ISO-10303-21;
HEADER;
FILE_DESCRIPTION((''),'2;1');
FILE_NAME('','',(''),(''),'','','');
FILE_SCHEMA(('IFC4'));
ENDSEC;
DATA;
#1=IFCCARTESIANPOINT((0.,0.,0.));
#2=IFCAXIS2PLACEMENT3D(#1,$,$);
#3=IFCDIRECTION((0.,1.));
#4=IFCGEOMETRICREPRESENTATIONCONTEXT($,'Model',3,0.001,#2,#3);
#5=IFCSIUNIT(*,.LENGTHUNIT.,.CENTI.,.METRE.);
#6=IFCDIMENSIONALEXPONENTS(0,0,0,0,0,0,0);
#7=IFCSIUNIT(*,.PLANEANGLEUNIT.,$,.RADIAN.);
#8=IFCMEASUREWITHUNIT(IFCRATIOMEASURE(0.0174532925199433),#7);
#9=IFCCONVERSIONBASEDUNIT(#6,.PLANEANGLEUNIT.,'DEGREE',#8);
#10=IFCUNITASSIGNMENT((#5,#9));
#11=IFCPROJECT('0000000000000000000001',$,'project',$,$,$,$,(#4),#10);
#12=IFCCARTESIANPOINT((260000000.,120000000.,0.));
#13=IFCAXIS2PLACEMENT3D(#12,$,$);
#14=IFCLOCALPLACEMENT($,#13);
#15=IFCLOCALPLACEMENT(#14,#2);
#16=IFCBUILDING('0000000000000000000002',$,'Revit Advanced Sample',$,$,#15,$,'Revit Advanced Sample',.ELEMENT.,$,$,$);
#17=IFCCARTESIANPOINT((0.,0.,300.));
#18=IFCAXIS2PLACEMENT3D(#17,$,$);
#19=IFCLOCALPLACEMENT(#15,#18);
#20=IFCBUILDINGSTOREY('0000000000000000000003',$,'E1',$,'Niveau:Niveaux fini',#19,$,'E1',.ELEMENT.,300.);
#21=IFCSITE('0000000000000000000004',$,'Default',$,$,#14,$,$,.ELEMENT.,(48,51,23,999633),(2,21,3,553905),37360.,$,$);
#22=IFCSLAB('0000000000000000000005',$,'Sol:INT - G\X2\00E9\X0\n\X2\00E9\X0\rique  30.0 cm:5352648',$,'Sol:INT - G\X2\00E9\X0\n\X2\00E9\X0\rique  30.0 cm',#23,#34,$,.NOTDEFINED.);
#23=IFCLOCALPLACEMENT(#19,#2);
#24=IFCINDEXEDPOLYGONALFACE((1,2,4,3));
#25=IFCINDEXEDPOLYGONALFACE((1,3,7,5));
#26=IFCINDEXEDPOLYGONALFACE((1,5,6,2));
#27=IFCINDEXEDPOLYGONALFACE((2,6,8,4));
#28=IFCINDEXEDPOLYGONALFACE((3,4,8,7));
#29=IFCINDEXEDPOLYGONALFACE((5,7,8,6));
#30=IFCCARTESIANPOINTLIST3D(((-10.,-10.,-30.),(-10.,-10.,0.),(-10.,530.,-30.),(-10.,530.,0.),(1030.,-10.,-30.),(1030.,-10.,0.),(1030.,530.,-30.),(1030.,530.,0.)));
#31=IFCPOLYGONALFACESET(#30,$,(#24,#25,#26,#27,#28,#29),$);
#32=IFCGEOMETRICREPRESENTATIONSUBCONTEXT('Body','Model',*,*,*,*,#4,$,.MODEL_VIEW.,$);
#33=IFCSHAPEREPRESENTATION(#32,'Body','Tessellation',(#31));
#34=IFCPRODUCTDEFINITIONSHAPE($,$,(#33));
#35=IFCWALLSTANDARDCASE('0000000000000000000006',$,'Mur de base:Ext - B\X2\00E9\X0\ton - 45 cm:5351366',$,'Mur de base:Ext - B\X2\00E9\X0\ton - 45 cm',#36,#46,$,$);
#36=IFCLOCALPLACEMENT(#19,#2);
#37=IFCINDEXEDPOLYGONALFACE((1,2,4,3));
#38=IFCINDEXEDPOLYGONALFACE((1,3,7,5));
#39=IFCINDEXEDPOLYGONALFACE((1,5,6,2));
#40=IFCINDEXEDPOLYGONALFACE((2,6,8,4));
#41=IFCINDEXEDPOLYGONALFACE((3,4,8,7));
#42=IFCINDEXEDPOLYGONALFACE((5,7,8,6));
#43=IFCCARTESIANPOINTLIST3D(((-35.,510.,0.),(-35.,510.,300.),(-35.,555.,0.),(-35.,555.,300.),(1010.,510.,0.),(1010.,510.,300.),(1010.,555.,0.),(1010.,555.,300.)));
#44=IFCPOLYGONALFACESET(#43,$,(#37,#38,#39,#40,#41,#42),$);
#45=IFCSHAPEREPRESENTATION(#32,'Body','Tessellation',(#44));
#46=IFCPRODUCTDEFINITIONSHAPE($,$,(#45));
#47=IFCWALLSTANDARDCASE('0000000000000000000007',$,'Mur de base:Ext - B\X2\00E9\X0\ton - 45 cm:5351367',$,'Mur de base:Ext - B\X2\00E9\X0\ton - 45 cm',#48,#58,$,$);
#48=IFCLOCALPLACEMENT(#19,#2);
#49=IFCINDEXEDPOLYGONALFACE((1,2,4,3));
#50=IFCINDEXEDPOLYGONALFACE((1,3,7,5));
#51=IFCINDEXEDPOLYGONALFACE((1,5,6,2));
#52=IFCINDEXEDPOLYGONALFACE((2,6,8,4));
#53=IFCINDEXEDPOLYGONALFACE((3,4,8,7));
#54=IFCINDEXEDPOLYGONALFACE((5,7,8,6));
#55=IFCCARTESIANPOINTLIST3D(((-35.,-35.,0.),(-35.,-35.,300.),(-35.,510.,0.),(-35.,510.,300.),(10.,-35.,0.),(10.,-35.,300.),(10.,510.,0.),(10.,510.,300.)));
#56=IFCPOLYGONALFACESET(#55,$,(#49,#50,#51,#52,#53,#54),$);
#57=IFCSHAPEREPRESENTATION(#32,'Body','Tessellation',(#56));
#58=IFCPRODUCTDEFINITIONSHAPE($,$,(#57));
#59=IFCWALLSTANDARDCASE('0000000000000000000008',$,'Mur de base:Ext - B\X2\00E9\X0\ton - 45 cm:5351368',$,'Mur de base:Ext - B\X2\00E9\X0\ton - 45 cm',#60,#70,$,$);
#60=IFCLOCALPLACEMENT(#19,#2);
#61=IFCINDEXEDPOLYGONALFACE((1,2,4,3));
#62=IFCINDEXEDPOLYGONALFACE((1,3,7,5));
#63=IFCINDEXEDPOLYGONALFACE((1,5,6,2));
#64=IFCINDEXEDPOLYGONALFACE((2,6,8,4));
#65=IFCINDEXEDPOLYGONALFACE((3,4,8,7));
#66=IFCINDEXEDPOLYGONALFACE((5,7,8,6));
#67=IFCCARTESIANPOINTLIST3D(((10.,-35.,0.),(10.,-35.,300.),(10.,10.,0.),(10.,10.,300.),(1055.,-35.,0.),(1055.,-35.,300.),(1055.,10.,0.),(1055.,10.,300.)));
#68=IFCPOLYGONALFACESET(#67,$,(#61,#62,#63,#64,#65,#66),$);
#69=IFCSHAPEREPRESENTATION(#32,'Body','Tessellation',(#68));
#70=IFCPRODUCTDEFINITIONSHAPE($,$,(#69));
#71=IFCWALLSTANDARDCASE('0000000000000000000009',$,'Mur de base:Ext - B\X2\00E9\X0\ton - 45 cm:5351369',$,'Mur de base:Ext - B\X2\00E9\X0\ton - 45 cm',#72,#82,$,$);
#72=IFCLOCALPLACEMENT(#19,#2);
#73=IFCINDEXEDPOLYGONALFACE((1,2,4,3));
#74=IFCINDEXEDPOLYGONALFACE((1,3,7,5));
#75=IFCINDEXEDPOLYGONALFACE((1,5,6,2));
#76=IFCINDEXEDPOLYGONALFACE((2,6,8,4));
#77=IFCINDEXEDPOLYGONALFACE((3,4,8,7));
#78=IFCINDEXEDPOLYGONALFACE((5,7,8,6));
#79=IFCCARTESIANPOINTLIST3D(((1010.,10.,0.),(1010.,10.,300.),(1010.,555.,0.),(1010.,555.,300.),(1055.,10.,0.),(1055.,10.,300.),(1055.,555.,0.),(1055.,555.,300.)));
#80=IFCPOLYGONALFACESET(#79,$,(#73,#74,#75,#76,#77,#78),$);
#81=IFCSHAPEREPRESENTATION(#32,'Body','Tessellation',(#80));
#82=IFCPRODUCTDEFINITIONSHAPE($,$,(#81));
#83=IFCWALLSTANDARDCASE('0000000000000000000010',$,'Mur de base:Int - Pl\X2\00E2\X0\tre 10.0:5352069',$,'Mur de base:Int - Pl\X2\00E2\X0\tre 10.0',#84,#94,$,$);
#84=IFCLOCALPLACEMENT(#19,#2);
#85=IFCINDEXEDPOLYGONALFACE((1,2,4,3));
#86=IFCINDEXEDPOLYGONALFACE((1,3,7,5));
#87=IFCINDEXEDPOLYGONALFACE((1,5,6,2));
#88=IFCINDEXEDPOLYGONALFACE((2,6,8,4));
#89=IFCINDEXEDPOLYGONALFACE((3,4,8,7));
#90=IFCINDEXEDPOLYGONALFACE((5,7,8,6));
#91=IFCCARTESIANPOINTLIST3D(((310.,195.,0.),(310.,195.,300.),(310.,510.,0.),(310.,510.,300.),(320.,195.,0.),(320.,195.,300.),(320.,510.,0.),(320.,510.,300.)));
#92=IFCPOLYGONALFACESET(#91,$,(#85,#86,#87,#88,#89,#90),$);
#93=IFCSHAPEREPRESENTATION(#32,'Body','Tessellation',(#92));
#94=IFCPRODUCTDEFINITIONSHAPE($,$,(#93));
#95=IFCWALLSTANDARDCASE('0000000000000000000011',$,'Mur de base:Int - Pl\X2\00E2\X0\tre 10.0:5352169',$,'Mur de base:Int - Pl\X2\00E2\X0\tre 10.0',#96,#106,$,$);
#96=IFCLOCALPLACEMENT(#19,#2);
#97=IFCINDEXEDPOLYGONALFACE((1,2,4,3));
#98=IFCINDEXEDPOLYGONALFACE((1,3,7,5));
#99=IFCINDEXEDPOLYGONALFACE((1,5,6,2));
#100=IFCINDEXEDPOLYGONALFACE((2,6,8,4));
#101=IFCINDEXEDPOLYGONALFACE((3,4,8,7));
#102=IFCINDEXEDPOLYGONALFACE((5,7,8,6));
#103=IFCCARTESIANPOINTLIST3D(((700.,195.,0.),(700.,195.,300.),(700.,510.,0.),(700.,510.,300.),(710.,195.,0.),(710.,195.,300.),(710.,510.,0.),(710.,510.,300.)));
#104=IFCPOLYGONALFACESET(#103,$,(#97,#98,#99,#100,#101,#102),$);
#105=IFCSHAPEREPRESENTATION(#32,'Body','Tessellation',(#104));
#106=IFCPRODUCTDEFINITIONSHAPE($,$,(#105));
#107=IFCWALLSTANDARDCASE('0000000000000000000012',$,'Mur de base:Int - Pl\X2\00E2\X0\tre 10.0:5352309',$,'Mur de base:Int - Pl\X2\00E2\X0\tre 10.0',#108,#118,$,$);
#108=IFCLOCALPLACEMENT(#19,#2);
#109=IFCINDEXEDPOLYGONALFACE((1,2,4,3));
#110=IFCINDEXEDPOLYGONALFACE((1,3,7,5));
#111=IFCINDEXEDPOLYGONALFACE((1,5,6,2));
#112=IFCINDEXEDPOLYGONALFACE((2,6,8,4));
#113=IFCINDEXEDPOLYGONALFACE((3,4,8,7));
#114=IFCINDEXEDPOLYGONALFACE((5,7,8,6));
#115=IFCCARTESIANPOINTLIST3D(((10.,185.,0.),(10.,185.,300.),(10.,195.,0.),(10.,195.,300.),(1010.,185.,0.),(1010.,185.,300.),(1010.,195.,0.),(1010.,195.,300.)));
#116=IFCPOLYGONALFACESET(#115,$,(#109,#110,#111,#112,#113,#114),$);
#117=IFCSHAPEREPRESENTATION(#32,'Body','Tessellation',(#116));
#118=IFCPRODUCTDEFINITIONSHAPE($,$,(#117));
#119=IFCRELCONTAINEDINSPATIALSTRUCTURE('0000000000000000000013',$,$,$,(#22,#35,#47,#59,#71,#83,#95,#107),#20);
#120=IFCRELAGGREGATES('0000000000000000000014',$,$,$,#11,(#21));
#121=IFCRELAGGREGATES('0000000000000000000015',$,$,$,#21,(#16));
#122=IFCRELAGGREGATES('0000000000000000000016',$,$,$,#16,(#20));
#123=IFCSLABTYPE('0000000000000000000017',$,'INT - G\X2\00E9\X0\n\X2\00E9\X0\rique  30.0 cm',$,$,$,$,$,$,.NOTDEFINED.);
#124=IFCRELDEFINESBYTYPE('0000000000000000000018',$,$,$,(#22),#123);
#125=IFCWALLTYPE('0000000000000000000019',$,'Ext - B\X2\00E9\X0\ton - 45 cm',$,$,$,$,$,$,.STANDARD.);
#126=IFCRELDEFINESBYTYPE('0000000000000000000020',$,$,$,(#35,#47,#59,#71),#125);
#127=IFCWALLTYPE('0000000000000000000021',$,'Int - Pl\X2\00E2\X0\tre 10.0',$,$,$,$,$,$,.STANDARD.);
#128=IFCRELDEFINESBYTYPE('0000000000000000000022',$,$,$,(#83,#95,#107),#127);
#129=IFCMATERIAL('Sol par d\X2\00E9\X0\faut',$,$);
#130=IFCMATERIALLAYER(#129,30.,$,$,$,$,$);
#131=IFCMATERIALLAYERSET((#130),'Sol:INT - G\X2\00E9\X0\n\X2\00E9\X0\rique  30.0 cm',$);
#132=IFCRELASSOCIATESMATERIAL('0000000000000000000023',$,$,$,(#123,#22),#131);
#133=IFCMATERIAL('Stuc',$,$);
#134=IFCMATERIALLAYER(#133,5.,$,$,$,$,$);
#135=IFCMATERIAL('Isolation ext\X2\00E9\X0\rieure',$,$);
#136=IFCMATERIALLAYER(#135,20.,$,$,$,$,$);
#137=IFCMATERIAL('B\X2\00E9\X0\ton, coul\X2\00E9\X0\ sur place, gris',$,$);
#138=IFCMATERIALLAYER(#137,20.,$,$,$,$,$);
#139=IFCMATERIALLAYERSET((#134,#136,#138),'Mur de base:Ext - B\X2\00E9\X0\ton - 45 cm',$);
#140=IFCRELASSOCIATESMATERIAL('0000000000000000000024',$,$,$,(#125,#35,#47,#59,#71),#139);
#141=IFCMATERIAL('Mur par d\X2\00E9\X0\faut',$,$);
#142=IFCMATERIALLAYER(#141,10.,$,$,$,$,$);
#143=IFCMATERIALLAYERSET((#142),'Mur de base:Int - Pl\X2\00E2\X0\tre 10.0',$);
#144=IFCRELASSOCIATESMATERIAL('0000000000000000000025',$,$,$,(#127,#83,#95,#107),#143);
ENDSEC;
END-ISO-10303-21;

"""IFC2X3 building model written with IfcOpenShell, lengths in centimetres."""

from ifc_helpers import new_model, entity, si_unit, converted_unit, direction, frame, frame_2d, origin, place, context, subcontext, project, spatial, rectangle, extrude, material, layer, layer_set, layer_usage, type_object, element, save


model = new_model("IFC2X3")

# Units and contexts
model_context = context("Model", 3, precision=0.001, world=origin(), true_north=direction((0.0, 1.0)))
body_context = subcontext(model_context, "Body", "Model", "MODEL_VIEW")
ifc_project = project(units=[si_unit("LENGTHUNIT", "METRE", prefix="CENTI"), converted_unit("PLANEANGLEUNIT", "DEGREE", entity("IfcRatioMeasure", 0.0174532925199433), si_unit("PLANEANGLEUNIT", "RADIAN"), dimensions=[0, 0, 0, 0, 0, 0, 0])], contexts=[model_context])

# Site, building, storey
site_placement = place(None, frame((260000000.0, 120000000.0, 0.0)))
site = spatial("IfcSite", under=ifc_project, at=site_placement, Name="Default", CompositionType="ELEMENT", RefLatitude=(48, 51, 23, 999633), RefLongitude=(2, 21, 3, 553905), RefElevation=37360.0)
building_placement = place(site_placement, origin())
building = spatial("IfcBuilding", under=site, at=building_placement, Name="Revit Advanced Sample", LongName="Revit Advanced Sample", CompositionType="ELEMENT")
storey_placement = place(building_placement, frame((0.0, 0.0, 300.0)))
storey = spatial("IfcBuildingStorey", under=building, at=storey_placement, Name="E1", ObjectType="Niveau:Niveaux fini", LongName="E1", CompositionType="ELEMENT", Elevation=300.0)

# Slab
ifc_material_1 = material(Name="Sol par défaut")
ifc_layer_1 = layer(ifc_material_1, 30.0)
ifc_layer_set_1 = layer_set([ifc_layer_1], Name="Sol:INT - Générique  30.0 cm")
ifc_layer_usage_1 = layer_usage(ifc_layer_set_1, "AXIS3", "POSITIVE", 0.0)
slab_type = type_object("IfcSlabType", Name="INT - Générique  30.0 cm", PredefinedType="NOTDEFINED", material=ifc_layer_set_1)
slab_placement = place(storey_placement, origin())
element("IfcSlab", 1, at=slab_placement, inside=storey, type_object=slab_type, material=ifc_layer_usage_1, Name="Sol:INT - Générique  30.0 cm:5352648", ObjectType="Sol:INT - Générique  30.0 cm", PredefinedType="NOTDEFINED", context=body_context, shape_type="SweptSolid", body=[
    extrude(rectangle(XDim=540.0, YDim=1040.0, at=frame_2d((0.0, 0.0), x_axis=(1.0, 0.0))), frame((510.0, 260.0, 0.0), z_axis=(0.0, 0.0, -1.0), x_axis=(0.0, 1.0, 0.0)), (0.0, 0.0, 1.0), 30.0),
])

# Walls
ifc_material_2 = material(Name="Stuc")
ifc_layer_2 = layer(ifc_material_2, 5.0)
ifc_material_3 = material(Name="Isolation extérieure")
ifc_layer_3 = layer(ifc_material_3, 20.0)
ifc_material_4 = material(Name="Béton, coulé sur place, gris")
ifc_layer_4 = layer(ifc_material_4, 20.0)
ifc_layer_set_2 = layer_set([ifc_layer_2, ifc_layer_3, ifc_layer_4], Name="Mur de base:Ext - Béton - 45 cm")
ifc_layer_usage_2 = layer_usage(ifc_layer_set_2, "AXIS2", "NEGATIVE", 22.5)
wall_type_1 = type_object("IfcWallType", Name="Ext - Béton - 45 cm", PredefinedType="STANDARD", material=ifc_layer_set_2)
wall_1_placement = place(storey_placement, frame((-35.0, 532.5, 0.0)))
element("IfcWallStandardCase", 2, at=wall_1_placement, inside=storey, type_object=wall_type_1, material=ifc_layer_usage_2, Name="Mur de base:Ext - Béton - 45 cm:5351366", ObjectType="Mur de base:Ext - Béton - 45 cm", context=body_context, shape_type="SweptSolid", body=[
    extrude(rectangle(XDim=1045.0, YDim=45.0, at=frame_2d((522.5, 0.0), x_axis=(-1.0, 0.0))), origin(), (0.0, 0.0, 1.0), 300.0),
])
ifc_layer_usage_3 = layer_usage(ifc_layer_set_2, "AXIS2", "NEGATIVE", 22.5)
wall_2_placement = place(storey_placement, frame((-12.5, -35.0, 0.0), z_axis=(0.0, 0.0, 1.0), x_axis=(0.0, 1.0, 0.0)))
element("IfcWallStandardCase", 3, at=wall_2_placement, inside=storey, type_object=wall_type_1, material=ifc_layer_usage_3, Name="Mur de base:Ext - Béton - 45 cm:5351367", ObjectType="Mur de base:Ext - Béton - 45 cm", context=body_context, shape_type="SweptSolid", body=[
    extrude(rectangle(XDim=545.0, YDim=45.0, at=frame_2d((272.5, 0.0), x_axis=(-1.0, 0.0))), origin(), (0.0, 0.0, 1.0), 300.0),
])
ifc_layer_usage_4 = layer_usage(ifc_layer_set_2, "AXIS2", "NEGATIVE", 22.5)
wall_3_placement = place(storey_placement, frame((1055.0, -12.5, 0.0), z_axis=(0.0, 0.0, 1.0), x_axis=(-1.0, 0.0, 0.0)))
element("IfcWallStandardCase", 4, at=wall_3_placement, inside=storey, type_object=wall_type_1, material=ifc_layer_usage_4, Name="Mur de base:Ext - Béton - 45 cm:5351368", ObjectType="Mur de base:Ext - Béton - 45 cm", context=body_context, shape_type="SweptSolid", body=[
    extrude(rectangle(XDim=1045.0, YDim=45.0, at=frame_2d((522.5, 0.0), x_axis=(-1.0, 0.0))), origin(), (0.0, 0.0, 1.0), 300.0),
])
ifc_layer_usage_5 = layer_usage(ifc_layer_set_2, "AXIS2", "NEGATIVE", 22.5)
wall_4_placement = place(storey_placement, frame((1032.5, 555.0, 0.0), z_axis=(0.0, 0.0, 1.0), x_axis=(0.0, -1.0, 0.0)))
element("IfcWallStandardCase", 5, at=wall_4_placement, inside=storey, type_object=wall_type_1, material=ifc_layer_usage_5, Name="Mur de base:Ext - Béton - 45 cm:5351369", ObjectType="Mur de base:Ext - Béton - 45 cm", context=body_context, shape_type="SweptSolid", body=[
    extrude(rectangle(XDim=545.0, YDim=45.0, at=frame_2d((272.5, 0.0), x_axis=(-1.0, 0.0))), origin(), (0.0, 0.0, 1.0), 300.0),
])
ifc_material_5 = material(Name="Mur par défaut")
ifc_layer_5 = layer(ifc_material_5, 10.0)
ifc_layer_set_3 = layer_set([ifc_layer_5], Name="Mur de base:Int - Plâtre 10.0")
ifc_layer_usage_6 = layer_usage(ifc_layer_set_3, "AXIS2", "NEGATIVE", 5.0)
wall_type_2 = type_object("IfcWallType", Name="Int - Plâtre 10.0", PredefinedType="STANDARD", material=ifc_layer_set_3)
wall_5_placement = place(storey_placement, frame((315.0, 510.0, 0.0), z_axis=(0.0, 0.0, 1.0), x_axis=(0.0, -1.0, 0.0)))
element("IfcWallStandardCase", 6, at=wall_5_placement, inside=storey, type_object=wall_type_2, material=ifc_layer_usage_6, Name="Mur de base:Int - Plâtre 10.0:5352069", ObjectType="Mur de base:Int - Plâtre 10.0", context=body_context, shape_type="SweptSolid", body=[
    extrude(rectangle(XDim=315.0, YDim=10.0, at=frame_2d((157.5, 0.0), x_axis=(-1.0, 0.0))), origin(), (0.0, 0.0, 1.0), 300.0),
])
ifc_layer_usage_7 = layer_usage(ifc_layer_set_3, "AXIS2", "NEGATIVE", 5.0)
wall_6_placement = place(storey_placement, frame((705.0, 510.0, 0.0), z_axis=(0.0, 0.0, 1.0), x_axis=(0.0, -1.0, 0.0)))
element("IfcWallStandardCase", 7, at=wall_6_placement, inside=storey, type_object=wall_type_2, material=ifc_layer_usage_7, Name="Mur de base:Int - Plâtre 10.0:5352169", ObjectType="Mur de base:Int - Plâtre 10.0", context=body_context, shape_type="SweptSolid", body=[
    extrude(rectangle(XDim=315.0, YDim=10.0, at=frame_2d((157.5, 0.0), x_axis=(-1.0, 0.0))), origin(), (0.0, 0.0, 1.0), 300.0),
])
ifc_layer_usage_8 = layer_usage(ifc_layer_set_3, "AXIS2", "NEGATIVE", 5.0)
wall_7_placement = place(storey_placement, frame((10.0, 190.0, 0.0)))
element("IfcWallStandardCase", 8, at=wall_7_placement, inside=storey, type_object=wall_type_2, material=ifc_layer_usage_8, Name="Mur de base:Int - Plâtre 10.0:5352309", ObjectType="Mur de base:Int - Plâtre 10.0", context=body_context, shape_type="SweptSolid", body=[
    extrude(rectangle(XDim=1000.0, YDim=10.0, at=frame_2d((500.0, 0.0), x_axis=(-1.0, 0.0))), origin(), (0.0, 0.0, 1.0), 300.0),
])

save(model, "model.ifc")
